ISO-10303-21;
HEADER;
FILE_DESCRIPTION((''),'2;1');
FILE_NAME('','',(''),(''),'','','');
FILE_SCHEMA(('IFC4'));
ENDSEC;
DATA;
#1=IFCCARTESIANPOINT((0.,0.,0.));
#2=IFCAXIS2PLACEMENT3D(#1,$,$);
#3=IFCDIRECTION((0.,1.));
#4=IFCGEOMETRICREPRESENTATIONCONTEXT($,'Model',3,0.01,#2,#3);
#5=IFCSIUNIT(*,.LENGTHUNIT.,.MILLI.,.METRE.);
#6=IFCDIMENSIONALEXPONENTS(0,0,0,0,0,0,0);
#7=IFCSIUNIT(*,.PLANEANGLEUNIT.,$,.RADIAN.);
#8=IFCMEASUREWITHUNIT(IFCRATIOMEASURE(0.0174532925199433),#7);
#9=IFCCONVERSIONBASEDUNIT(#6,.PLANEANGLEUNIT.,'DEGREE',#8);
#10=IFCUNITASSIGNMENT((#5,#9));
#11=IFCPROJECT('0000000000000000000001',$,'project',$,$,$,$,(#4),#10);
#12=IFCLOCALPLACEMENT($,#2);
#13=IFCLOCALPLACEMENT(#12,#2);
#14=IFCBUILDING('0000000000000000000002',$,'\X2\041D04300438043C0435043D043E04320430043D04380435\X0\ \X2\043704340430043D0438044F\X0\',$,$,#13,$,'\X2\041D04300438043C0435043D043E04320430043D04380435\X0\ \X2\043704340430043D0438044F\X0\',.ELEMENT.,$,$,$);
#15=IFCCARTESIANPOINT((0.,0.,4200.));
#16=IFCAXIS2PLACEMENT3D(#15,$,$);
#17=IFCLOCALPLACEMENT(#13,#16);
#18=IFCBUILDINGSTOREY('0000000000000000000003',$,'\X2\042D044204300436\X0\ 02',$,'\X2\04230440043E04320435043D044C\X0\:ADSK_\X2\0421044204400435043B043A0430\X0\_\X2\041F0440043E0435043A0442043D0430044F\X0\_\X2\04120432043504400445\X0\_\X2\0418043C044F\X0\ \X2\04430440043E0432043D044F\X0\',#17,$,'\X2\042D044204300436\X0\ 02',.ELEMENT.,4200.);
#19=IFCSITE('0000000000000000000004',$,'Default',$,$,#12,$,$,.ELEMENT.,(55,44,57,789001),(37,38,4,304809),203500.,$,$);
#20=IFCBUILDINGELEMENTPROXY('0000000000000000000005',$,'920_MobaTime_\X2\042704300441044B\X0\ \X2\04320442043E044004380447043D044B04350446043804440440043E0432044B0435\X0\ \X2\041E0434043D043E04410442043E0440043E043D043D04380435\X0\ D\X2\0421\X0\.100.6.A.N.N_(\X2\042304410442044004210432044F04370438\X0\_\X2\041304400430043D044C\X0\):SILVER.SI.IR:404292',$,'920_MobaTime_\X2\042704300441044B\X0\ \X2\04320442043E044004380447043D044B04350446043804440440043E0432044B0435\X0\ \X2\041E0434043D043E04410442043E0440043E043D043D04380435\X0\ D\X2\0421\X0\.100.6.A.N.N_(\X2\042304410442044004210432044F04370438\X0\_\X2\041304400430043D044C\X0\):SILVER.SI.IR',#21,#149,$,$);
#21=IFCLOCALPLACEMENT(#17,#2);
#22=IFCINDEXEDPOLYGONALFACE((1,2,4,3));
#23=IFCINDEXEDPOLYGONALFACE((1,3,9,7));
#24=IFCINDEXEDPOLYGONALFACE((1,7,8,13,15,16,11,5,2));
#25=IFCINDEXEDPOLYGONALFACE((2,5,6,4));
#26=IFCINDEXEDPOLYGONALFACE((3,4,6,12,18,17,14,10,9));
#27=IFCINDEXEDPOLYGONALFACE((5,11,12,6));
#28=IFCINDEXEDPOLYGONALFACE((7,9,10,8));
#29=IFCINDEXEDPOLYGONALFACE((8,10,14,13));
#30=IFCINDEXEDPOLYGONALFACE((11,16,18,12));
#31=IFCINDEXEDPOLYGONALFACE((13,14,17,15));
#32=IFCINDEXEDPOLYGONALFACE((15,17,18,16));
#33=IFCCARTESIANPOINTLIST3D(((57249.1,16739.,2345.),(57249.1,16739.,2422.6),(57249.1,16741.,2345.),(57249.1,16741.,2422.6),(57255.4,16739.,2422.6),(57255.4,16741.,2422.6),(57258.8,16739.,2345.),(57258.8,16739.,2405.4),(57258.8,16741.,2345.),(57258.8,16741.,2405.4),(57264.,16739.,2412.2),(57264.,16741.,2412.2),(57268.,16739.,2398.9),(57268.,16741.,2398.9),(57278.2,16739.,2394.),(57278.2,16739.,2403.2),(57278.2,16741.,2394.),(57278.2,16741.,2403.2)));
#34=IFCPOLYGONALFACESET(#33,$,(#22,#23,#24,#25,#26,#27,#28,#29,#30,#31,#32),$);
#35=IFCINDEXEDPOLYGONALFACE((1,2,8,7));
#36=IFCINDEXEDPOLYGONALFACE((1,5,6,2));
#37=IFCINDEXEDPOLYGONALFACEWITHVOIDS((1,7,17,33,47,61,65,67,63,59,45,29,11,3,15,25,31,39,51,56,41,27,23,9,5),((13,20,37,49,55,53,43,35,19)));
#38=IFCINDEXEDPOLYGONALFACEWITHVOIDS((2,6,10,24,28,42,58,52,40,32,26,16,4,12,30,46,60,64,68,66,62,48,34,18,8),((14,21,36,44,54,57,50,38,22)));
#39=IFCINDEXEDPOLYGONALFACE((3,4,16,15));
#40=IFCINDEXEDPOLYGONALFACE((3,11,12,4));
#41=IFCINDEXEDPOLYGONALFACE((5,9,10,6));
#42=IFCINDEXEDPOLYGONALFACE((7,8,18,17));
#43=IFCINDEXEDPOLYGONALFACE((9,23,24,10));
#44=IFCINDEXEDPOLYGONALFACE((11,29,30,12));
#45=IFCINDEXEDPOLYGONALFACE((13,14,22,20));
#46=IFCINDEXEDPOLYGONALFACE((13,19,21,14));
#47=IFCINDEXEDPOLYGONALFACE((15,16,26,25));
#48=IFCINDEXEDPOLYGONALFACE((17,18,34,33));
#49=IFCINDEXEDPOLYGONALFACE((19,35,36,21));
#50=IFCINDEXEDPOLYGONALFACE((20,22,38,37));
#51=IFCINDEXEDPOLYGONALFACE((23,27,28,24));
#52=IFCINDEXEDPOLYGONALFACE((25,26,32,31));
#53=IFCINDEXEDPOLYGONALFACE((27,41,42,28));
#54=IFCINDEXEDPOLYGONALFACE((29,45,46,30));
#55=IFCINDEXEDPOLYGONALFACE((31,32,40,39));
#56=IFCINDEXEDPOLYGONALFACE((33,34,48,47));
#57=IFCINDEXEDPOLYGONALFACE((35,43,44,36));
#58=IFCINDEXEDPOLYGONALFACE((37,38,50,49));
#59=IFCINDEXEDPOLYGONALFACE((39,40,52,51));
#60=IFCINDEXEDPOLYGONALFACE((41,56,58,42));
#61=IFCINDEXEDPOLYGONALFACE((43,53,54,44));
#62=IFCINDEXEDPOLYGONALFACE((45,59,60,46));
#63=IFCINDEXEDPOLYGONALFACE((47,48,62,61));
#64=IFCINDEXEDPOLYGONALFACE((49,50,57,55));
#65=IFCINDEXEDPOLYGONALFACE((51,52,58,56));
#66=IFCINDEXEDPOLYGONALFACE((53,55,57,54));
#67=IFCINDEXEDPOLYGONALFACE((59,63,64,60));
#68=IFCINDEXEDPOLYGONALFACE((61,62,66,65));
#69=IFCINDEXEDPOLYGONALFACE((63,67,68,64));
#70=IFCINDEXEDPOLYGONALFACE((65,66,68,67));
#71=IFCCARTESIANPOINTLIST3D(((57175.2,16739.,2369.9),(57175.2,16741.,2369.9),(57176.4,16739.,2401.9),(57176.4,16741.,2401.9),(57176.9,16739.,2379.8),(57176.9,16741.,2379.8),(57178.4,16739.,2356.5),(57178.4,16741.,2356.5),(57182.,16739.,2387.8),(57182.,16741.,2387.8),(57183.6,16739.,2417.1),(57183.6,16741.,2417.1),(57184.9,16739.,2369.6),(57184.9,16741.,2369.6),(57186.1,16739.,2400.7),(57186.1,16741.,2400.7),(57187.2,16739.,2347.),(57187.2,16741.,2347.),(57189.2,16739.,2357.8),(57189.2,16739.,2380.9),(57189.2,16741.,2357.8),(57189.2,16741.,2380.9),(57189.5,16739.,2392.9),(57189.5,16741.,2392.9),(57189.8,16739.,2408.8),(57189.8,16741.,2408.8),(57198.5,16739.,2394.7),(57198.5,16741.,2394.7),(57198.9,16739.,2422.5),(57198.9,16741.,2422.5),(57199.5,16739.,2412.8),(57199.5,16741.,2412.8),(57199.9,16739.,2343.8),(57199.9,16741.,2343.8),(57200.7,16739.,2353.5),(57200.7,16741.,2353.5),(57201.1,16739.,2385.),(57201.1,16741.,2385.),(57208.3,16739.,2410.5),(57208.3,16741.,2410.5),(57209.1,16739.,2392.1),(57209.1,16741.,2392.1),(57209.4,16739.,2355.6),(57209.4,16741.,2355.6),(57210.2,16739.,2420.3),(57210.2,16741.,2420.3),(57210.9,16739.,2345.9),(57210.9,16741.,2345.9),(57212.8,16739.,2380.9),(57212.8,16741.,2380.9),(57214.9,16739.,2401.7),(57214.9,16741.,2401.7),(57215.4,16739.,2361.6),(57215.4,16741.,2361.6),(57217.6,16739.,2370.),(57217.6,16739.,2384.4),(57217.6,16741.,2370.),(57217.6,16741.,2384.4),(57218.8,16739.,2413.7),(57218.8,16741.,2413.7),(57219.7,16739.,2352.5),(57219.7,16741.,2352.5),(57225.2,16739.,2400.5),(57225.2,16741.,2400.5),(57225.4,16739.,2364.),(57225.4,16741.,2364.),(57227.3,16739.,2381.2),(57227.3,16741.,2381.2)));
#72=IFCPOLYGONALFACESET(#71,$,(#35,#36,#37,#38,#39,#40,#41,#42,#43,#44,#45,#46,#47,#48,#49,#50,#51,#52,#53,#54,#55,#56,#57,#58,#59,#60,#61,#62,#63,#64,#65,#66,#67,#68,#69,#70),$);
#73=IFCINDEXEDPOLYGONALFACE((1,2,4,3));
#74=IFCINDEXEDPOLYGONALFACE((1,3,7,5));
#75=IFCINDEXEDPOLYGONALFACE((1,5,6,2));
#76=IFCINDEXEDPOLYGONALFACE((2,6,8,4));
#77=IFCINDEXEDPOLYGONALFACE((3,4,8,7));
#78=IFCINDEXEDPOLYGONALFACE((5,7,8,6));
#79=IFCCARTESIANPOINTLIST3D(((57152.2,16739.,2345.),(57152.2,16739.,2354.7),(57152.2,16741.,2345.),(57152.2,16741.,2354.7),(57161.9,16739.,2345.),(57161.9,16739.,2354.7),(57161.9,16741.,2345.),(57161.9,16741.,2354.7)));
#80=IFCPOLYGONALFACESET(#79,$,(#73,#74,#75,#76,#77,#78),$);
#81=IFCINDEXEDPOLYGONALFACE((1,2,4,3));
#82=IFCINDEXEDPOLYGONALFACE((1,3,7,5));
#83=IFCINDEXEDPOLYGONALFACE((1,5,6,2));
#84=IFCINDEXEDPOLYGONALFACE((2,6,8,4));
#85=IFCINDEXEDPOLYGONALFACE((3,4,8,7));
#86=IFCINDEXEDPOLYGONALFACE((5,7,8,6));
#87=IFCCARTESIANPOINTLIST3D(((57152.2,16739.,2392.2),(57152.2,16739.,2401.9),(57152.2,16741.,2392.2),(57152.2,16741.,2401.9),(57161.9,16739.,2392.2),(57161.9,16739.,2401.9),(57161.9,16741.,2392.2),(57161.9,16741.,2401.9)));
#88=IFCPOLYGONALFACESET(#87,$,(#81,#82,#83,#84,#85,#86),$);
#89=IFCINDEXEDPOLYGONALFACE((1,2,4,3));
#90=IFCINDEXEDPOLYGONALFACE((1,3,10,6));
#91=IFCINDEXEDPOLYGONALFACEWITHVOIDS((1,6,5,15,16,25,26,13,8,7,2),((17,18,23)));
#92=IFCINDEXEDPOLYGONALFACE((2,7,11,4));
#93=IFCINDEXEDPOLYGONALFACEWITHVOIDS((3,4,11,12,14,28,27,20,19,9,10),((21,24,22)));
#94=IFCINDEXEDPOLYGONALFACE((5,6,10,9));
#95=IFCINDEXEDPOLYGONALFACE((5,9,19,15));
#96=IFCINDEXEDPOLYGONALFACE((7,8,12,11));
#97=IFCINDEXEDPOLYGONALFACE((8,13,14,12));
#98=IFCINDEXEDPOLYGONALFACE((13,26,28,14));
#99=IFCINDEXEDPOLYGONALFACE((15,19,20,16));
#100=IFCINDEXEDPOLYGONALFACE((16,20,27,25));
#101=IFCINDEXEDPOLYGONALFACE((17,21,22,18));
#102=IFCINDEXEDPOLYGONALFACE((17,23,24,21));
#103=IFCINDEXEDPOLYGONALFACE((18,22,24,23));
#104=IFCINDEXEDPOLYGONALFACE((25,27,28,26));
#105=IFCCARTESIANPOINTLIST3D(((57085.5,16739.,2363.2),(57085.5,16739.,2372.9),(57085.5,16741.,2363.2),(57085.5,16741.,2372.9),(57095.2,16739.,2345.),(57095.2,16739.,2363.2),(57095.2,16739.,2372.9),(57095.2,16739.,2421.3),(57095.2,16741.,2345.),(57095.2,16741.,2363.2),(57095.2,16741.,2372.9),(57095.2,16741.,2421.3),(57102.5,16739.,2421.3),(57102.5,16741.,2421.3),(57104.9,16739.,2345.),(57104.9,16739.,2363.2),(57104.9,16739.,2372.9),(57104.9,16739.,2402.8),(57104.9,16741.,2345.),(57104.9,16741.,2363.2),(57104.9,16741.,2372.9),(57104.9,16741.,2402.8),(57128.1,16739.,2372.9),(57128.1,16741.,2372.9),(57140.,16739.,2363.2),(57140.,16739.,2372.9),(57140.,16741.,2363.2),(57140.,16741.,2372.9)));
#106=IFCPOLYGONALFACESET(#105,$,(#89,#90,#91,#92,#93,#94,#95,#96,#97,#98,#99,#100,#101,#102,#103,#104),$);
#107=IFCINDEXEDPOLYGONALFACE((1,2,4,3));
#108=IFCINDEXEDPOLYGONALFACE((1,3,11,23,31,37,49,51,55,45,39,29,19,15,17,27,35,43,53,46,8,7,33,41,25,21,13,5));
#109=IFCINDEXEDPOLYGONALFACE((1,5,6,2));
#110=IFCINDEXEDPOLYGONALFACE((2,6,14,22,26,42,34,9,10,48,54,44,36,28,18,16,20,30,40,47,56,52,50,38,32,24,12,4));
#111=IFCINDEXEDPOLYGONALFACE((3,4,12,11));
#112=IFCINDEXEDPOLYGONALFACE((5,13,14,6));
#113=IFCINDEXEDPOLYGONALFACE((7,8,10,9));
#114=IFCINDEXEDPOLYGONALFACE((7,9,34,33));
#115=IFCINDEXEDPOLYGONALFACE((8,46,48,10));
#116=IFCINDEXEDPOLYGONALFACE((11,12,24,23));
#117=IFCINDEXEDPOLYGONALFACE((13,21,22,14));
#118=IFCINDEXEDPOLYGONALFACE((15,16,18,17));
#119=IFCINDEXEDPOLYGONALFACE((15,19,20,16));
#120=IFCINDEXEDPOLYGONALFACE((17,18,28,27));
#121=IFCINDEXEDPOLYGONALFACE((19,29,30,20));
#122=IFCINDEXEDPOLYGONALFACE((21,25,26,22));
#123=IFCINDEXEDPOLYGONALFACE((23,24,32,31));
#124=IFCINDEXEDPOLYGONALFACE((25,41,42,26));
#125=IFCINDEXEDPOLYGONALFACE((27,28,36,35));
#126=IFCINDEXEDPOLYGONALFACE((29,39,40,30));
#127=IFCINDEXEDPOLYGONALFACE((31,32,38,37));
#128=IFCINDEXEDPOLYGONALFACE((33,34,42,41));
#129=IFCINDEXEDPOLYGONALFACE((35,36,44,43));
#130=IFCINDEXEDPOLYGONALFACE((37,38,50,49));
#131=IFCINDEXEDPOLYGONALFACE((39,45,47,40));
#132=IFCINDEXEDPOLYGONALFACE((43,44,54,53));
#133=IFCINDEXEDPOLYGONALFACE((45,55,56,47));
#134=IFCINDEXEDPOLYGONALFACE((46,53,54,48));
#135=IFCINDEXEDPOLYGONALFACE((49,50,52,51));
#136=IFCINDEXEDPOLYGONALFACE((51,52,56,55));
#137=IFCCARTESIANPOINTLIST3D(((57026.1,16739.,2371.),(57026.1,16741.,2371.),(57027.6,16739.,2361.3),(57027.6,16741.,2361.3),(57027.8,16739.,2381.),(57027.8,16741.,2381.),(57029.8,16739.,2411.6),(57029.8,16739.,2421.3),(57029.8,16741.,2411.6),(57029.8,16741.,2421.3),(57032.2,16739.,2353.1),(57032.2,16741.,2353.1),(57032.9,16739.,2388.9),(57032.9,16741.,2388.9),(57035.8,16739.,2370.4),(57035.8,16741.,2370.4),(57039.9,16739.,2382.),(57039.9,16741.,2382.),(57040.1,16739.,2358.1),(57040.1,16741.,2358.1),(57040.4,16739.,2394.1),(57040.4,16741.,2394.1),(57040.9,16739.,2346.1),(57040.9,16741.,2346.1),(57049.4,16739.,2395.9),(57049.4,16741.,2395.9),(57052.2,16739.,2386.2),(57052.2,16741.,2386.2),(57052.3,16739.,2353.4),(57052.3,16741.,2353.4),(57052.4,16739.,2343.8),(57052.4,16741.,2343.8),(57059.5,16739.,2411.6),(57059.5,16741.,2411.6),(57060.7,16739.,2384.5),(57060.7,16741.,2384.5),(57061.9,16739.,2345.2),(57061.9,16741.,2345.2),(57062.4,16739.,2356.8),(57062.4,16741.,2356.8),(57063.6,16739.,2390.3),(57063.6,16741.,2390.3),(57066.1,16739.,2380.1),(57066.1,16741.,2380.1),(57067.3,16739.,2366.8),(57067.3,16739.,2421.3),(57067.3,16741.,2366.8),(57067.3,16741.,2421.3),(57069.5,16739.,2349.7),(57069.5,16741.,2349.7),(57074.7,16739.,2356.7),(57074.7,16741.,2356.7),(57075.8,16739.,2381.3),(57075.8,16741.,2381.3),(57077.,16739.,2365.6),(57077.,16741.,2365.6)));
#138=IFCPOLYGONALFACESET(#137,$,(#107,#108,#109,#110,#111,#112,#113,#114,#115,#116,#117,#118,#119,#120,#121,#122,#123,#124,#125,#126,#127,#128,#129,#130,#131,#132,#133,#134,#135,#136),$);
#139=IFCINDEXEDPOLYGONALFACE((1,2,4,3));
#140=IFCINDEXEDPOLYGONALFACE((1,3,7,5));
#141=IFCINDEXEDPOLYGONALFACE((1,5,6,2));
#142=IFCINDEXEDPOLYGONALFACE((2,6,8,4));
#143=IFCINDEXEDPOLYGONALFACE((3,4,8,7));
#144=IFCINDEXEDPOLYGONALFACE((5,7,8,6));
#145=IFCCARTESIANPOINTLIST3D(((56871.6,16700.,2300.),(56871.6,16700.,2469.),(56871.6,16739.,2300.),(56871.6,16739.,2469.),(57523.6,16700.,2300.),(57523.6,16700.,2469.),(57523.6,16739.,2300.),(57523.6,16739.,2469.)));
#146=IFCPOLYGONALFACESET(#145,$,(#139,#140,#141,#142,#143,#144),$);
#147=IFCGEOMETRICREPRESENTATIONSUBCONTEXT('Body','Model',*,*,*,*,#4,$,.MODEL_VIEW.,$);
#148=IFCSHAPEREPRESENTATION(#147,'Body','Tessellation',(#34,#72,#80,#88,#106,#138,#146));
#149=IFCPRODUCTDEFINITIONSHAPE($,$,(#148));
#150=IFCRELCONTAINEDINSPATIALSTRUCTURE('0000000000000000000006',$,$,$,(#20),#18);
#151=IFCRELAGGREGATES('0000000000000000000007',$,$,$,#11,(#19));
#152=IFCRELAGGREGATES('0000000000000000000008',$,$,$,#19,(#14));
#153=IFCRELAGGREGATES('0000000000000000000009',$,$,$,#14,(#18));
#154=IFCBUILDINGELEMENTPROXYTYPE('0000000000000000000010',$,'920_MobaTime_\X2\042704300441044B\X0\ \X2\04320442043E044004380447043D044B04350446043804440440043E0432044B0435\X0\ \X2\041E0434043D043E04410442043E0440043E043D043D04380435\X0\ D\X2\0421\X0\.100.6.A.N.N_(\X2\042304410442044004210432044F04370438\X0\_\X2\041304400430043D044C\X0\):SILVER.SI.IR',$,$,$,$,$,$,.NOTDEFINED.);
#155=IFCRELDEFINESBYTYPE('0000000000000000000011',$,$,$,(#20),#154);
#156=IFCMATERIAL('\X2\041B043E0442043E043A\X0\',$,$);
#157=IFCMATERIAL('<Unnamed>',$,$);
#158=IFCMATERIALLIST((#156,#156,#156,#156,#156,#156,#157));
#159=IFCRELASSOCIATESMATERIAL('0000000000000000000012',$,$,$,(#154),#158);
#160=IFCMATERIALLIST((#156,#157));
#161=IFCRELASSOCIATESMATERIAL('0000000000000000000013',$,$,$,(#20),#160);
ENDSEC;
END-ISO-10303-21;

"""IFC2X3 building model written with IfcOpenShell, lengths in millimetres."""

from ifc_helpers import new_model, entity, si_unit, converted_unit, direction, frame, origin, origin_2d_with_axis, place, context, subcontext, project, spatial, polyline, rectangle, outline, extrude, source, transform, mapped, material, material_list, type_object, type_shapes, element, save


model = new_model("IFC2X3")

# Units and contexts
model_context = context("Model", 3, precision=0.01, world=origin(), true_north=direction((0.0, 1.0)))
body_context = subcontext(model_context, "Body", "Model", "MODEL_VIEW")
ifc_project = project(units=[si_unit("LENGTHUNIT", "METRE", prefix="MILLI"), converted_unit("PLANEANGLEUNIT", "DEGREE", entity("IfcRatioMeasure", 0.0174532925199433), si_unit("PLANEANGLEUNIT", "RADIAN"), dimensions=[0, 0, 0, 0, 0, 0, 0])], contexts=[model_context])

# Site, building, storey
site_placement = place(None, origin())
site = spatial("IfcSite", under=ifc_project, at=site_placement, Name="Default", CompositionType="ELEMENT", RefLatitude=(55, 44, 57, 789001), RefLongitude=(37, 38, 4, 304809), RefElevation=203500.0)
building_placement = place(site_placement, origin())
building = spatial("IfcBuilding", under=site, at=building_placement, Name="Наименование здания", LongName="Наименование здания", CompositionType="ELEMENT")
storey_placement = place(building_placement, frame((0.0, 0.0, 4200.0)))
storey = spatial("IfcBuildingStorey", under=building, at=storey_placement, Name="Этаж 02", ObjectType="Уровень:ADSK_Стрелка_Проектная_Вверх_Имя уровня", LongName="Этаж 02", CompositionType="ELEMENT", Elevation=4200.0)

# Building element proxy
ifc_material_1 = material(Name="Лоток")
ifc_material_2 = material(Name="<Unnamed>")
ifc_material_list_1 = material_list([ifc_material_1, ifc_material_2])
ifc_material_list_2 = material_list([ifc_material_1, ifc_material_1, ifc_material_1, ifc_material_1, ifc_material_1, ifc_material_1, ifc_material_2])
building_element_proxy_type_1 = type_object("IfcBuildingElementProxyType", Name="920_MobaTime_Часы вторичныецифровые Односторонние DС.100.6.A.N.N_(УстрСвязи_Грань):SILVER.SI.IR", PredefinedType="NOTDEFINED", material=ifc_material_list_2)
shared_shape_1 = source(origin(), body_context, "Body", "SweptSolid", [
    extrude(outline(polyline([(-49.3, -13.1), (28.2, -13.1), (28.2, -6.8), (17.9, 1.8), (8.8, 16.0), (-0.3, 16.0), (4.6, 5.8), (11.1, -3.4), (-49.3, -3.4), (-49.3, -13.1)])), frame((-64.6, 9.8, 39.0), z_axis=(0.0, 0.0, 1.0), x_axis=(0.0, 1.0, 0.0)), (0.0, 0.0, 1.0), 2.0),
    extrude(outline(polyline([(2.2, -27.6), (19.0, -27.6), (30.5, -16.1), (33.3, -4.9), (31.0, 5.8), (21.8, 17.2), (5.2, 27.3), (-11.1, 33.0), (-24.0, 32.7), (-33.6, 27.6), (-40.3, 18.6), (-42.8, 5.7), (-38.0, -6.3), (-27.2, -14.9), (-17.5, -17.7), (-8.2, -16.4), (-0.3, -11.9), (5.1, -4.5), (7.3, 6.2), (4.0, 17.2), (18.4, 7.3), (23.6, -2.4), (22.0, -11.4), (14.2, -18.4), (5.3, -18.3), (2.2, -27.6)]), holes=[polyline([(-9.0, 23.3), (-1.3, 14.3), (-2.5, 2.0), (-11.4, -7.0), (-23.4, -6.0), (-32.2, 2.9), (-31.2, 15.1), (-25.6, 22.1), (-17.5, 24.9), (-9.0, 23.3)])]), frame((-2.7, 3.6, 39.0), z_axis=(0.0, 0.0, 1.0), x_axis=(-0.427649, 0.903945, 0.0)), (0.0, 0.0, 1.0), 2.0),
    extrude(rectangle(XDim=9.7, YDim=9.7, at=origin_2d_with_axis()), frame((40.6, -34.7, 39.0)), (0.0, 0.0, 1.0), 2.0),
    extrude(rectangle(XDim=9.7, YDim=9.7, at=origin_2d_with_axis()), frame((40.6, 12.6, 39.0)), (0.0, 0.0, 1.0), 2.0),
    extrude(outline(polyline([(-0.9, -28.1), (8.8, -28.1), (8.8, -9.9), (18.5, -9.9), (18.5, -0.2), (8.8, -0.2), (8.8, 48.3), (1.5, 48.3), (-36.0, -0.2), (-36.0, -9.9), (-0.9, -9.9), (-0.9, -28.1)]), holes=[polyline([(-0.9, -0.2), (-24.1, -0.2), (-0.9, 29.7), (-0.9, -0.2)])]), frame((93.6, -11.4, 39.0)), (0.0, 0.0, 1.0), 2.0),
    extrude(outline(polyline([(3.3, -28.3), (12.5, -28.3), (20.5, -25.0), (26.8, -18.9), (30.7, -10.0), (31.4, 1.6), (26.9, 11.8), (20.1, 18.4), (11.1, 22.3), (1.0, 23.3), (-7.9, 20.4), (-14.9, 14.5), (-18.9, 6.2), (-17.1, -9.0), (-36.7, 0.5), (-29.1, 29.2), (-38.5, 31.7), (-48.1, -4.6), (-11.6, -23.1), (-8.0, -14.0), (-10.8, -7.6), (-10.2, 1.1), (-3.0, 11.8), (9.2, 12.8), (20.0, 5.5), (21.4, -7.5), (15.5, -16.4), (4.6, -18.6), (3.3, -28.3)])), frame((147.1, -8.5, 39.0), z_axis=(0.0, 0.0, 1.0), x_axis=(0.256974, -0.966418, 0.0)), (0.0, 0.0, 1.0), 2.0),
    extrude(rectangle(XDim=652.0, YDim=169.0, at=origin_2d_with_axis()), frame((0.0, 0.0, 0.0), z_axis=(0.0, 0.0, 1.0), x_axis=(-1.0, 0.0, 0.0)), (0.0, 0.0, 1.0), 39.0),
])
type_shapes(building_element_proxy_type_1, [shared_shape_1])
for number, where, z_axis, x_axis, name in (
    (1, (57197.6, 16700.0, 2384.5), (0.0, 1.0, 0.0), (-1.0, 0.0, 0.0), "920_MobaTime_Часы вторичныецифровые Односторонние DС.100.6.A.N.N_(УстрСвязи_Грань):SILVER.SI.IR:404292"),
):
    element("IfcBuildingElementProxy", number, at=place(storey_placement, frame(where, z_axis=z_axis, x_axis=x_axis)), inside=storey, type_object=building_element_proxy_type_1, material=ifc_material_list_1, Name=name, ObjectType="920_MobaTime_Часы вторичныецифровые Односторонние DС.100.6.A.N.N_(УстрСвязи_Грань):SILVER.SI.IR", context=body_context, shape_type="MappedRepresentation", body=[
        mapped(shared_shape_1, transform((0.0, 0.0, 0.0), scale=1.0)),
    ])

save(model, "model.ifc")
